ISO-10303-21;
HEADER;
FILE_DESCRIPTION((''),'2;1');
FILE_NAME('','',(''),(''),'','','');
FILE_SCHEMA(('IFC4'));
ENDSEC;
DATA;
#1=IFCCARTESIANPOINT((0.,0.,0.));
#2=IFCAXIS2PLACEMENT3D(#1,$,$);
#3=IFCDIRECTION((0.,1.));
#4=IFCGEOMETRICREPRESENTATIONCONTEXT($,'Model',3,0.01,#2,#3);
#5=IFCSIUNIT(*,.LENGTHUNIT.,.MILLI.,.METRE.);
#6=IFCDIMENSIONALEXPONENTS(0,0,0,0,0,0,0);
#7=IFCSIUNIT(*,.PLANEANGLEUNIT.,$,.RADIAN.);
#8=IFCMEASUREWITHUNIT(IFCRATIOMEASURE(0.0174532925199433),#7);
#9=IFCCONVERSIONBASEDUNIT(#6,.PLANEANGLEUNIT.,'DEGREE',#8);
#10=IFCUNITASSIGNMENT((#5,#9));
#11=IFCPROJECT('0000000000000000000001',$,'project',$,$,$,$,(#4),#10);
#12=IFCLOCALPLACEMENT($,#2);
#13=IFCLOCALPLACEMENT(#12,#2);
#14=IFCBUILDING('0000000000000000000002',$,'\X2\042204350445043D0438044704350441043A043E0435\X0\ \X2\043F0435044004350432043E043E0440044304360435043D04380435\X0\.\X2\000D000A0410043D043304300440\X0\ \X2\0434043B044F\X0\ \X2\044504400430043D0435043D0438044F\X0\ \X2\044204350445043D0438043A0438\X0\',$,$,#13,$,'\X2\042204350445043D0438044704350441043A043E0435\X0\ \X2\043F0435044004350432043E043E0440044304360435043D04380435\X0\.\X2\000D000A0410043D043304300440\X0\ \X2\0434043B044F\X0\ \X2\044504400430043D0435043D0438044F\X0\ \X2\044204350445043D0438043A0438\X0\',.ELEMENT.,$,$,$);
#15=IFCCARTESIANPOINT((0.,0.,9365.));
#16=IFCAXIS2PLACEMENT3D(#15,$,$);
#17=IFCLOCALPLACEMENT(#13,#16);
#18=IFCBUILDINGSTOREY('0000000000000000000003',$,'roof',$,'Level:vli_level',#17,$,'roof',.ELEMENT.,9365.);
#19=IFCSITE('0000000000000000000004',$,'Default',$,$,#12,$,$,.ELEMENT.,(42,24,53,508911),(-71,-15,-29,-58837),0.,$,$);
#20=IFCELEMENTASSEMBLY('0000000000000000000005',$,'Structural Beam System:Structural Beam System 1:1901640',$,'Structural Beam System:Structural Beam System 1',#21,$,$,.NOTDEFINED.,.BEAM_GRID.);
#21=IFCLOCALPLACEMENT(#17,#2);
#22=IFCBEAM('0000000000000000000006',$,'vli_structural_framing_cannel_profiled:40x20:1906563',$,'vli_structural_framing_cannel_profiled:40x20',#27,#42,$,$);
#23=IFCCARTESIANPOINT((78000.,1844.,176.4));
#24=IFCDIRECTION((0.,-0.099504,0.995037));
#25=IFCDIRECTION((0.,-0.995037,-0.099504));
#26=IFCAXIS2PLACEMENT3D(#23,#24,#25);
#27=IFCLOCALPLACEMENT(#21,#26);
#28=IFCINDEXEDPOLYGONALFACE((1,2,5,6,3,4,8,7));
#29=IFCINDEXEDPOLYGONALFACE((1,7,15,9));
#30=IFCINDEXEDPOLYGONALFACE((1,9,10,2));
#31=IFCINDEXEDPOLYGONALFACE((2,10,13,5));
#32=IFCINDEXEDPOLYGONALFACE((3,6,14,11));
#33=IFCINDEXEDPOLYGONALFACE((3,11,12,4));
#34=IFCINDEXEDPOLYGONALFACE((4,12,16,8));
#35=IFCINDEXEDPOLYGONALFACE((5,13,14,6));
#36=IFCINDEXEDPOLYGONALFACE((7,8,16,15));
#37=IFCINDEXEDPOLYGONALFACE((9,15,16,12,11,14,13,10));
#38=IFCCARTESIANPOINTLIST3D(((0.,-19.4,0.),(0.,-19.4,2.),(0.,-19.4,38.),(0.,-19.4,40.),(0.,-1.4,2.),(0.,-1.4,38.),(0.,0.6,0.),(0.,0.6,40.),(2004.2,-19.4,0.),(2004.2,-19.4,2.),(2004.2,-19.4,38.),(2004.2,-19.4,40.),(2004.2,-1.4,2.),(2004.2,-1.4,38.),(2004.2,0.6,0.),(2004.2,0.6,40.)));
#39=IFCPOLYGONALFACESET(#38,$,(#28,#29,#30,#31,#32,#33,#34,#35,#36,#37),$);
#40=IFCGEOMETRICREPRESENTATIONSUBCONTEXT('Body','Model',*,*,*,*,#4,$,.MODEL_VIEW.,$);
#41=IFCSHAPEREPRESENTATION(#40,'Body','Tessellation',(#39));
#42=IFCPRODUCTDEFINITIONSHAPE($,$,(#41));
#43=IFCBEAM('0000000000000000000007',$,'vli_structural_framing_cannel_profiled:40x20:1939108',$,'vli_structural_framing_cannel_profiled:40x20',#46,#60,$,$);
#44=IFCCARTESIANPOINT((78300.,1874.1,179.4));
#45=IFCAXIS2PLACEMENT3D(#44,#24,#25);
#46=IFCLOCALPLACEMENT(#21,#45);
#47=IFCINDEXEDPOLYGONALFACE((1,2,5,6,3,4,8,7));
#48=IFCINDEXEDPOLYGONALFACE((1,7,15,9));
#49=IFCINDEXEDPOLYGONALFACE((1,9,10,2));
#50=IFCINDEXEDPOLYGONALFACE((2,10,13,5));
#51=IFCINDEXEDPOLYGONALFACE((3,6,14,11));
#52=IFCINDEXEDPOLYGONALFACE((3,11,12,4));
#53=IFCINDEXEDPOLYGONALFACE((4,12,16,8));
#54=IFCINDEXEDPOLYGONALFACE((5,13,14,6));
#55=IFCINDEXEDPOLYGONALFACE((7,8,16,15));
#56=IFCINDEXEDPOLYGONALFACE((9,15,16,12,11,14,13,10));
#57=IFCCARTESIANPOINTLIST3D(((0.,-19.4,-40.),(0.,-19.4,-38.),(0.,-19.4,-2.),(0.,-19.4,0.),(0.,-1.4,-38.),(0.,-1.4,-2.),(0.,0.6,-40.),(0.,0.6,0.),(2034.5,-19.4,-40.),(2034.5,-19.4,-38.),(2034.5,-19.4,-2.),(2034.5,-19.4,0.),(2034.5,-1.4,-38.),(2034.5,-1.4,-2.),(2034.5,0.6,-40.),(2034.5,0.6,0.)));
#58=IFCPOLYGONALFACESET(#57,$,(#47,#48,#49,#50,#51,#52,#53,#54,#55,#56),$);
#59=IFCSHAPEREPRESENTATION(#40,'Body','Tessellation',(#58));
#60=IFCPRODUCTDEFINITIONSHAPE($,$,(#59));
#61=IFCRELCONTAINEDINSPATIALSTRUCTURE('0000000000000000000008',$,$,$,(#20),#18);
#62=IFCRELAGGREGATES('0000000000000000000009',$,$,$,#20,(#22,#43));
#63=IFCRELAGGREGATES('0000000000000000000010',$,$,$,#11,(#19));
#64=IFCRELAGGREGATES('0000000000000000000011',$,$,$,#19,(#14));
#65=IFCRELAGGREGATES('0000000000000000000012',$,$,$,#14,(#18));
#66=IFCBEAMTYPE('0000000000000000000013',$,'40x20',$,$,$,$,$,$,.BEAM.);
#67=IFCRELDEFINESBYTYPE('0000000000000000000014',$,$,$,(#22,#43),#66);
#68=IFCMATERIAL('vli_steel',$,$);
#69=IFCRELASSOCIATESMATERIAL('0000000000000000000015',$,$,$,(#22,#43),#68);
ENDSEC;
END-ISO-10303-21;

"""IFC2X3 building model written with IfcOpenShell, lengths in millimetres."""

from ifc_helpers import new_model, entity, si_unit, converted_unit, direction, frame, origin, place, context, subcontext, project, spatial, polyline, outline, extrude, material, type_object, element, aggregate, save


model = new_model("IFC2X3")

# Units and contexts
model_context = context("Model", 3, precision=0.01, world=origin(), true_north=direction((0.0, 1.0)))
body_context = subcontext(model_context, "Body", "Model", "MODEL_VIEW")
ifc_project = project(units=[si_unit("LENGTHUNIT", "METRE", prefix="MILLI"), converted_unit("PLANEANGLEUNIT", "DEGREE", entity("IfcRatioMeasure", 0.0174532925199433), si_unit("PLANEANGLEUNIT", "RADIAN"), dimensions=[0, 0, 0, 0, 0, 0, 0])], contexts=[model_context])

# Site, building, storey
site_placement = place(None, origin())
site = spatial("IfcSite", under=ifc_project, at=site_placement, Name="Default", CompositionType="ELEMENT", RefLatitude=(42, 24, 53, 508911), RefLongitude=(-71, -15, -29, -58837), RefElevation=0.0)
building_placement = place(site_placement, origin())
building = spatial("IfcBuilding", under=site, at=building_placement, Name="Техническое перевооружение.\r\nАнгар для хранения техники", LongName="Техническое перевооружение.\r\nАнгар для хранения техники", CompositionType="ELEMENT")
storey_placement = place(building_placement, frame((0.0, 0.0, 9365.0)))
storey = spatial("IfcBuildingStorey", under=building, at=storey_placement, Name="roof", ObjectType="Level:vli_level", LongName="roof", CompositionType="ELEMENT", Elevation=9365.0)

# Element assembly, beams
assembly_1_placement = place(storey_placement, origin())
assembly_1 = element("IfcElementAssembly", 1, at=assembly_1_placement, inside=storey, Name="Structural Beam System:Structural Beam System 1:1901640", ObjectType="Structural Beam System:Structural Beam System 1", AssemblyPlace="NOTDEFINED", PredefinedType="BEAM_GRID")
ifc_material = material(Name="vli_steel")
beam_type = type_object("IfcBeamType", Name="40x20", PredefinedType="BEAM")
beam_1_placement = place(assembly_1_placement, frame((78000.0, 1844.0, 176.4), z_axis=(0.0, -0.099504, 0.995037), x_axis=(0.0, -0.995037, -0.099504)))
beam_1 = element("IfcBeam", 2, at=beam_1_placement, type_object=beam_type, material=ifc_material, Name="vli_structural_framing_cannel_profiled:40x20:1906563", ObjectType="vli_structural_framing_cannel_profiled:40x20", context=body_context, shape_type="SweptSolid", body=[
    extrude(outline(polyline([(-20.0, -9.5), (-18.0, -9.5), (-18.0, 8.5), (18.0, 8.5), (18.0, -9.5), (20.0, -9.5), (20.0, 10.5), (-20.0, 10.5), (-20.0, -9.5)])), frame((0.0, -9.9, 20.0), z_axis=(1.0, 0.0, 0.0), x_axis=(0.0, 0.0, -1.0)), (0.0, 0.0, 1.0), 2004.2),
])
beam_2_placement = place(assembly_1_placement, frame((78300.0, 1874.1, 179.4), z_axis=(0.0, -0.099504, 0.995037), x_axis=(0.0, -0.995037, -0.099504)))
beam_2 = element("IfcBeam", 3, at=beam_2_placement, type_object=beam_type, material=ifc_material, Name="vli_structural_framing_cannel_profiled:40x20:1939108", ObjectType="vli_structural_framing_cannel_profiled:40x20", context=body_context, shape_type="SweptSolid", body=[
    extrude(outline(polyline([(-20.0, -9.5), (-18.0, -9.5), (-18.0, 8.5), (18.0, 8.5), (18.0, -9.5), (20.0, -9.5), (20.0, 10.5), (-20.0, 10.5), (-20.0, -9.5)])), frame((0.0, -9.9, -20.0), z_axis=(1.0, 0.0, 0.0), x_axis=(0.0, 0.0, -1.0)), (0.0, 0.0, 1.0), 2034.5),
])
aggregate(assembly_1, [beam_1, beam_2])

save(model, "model.ifc")
